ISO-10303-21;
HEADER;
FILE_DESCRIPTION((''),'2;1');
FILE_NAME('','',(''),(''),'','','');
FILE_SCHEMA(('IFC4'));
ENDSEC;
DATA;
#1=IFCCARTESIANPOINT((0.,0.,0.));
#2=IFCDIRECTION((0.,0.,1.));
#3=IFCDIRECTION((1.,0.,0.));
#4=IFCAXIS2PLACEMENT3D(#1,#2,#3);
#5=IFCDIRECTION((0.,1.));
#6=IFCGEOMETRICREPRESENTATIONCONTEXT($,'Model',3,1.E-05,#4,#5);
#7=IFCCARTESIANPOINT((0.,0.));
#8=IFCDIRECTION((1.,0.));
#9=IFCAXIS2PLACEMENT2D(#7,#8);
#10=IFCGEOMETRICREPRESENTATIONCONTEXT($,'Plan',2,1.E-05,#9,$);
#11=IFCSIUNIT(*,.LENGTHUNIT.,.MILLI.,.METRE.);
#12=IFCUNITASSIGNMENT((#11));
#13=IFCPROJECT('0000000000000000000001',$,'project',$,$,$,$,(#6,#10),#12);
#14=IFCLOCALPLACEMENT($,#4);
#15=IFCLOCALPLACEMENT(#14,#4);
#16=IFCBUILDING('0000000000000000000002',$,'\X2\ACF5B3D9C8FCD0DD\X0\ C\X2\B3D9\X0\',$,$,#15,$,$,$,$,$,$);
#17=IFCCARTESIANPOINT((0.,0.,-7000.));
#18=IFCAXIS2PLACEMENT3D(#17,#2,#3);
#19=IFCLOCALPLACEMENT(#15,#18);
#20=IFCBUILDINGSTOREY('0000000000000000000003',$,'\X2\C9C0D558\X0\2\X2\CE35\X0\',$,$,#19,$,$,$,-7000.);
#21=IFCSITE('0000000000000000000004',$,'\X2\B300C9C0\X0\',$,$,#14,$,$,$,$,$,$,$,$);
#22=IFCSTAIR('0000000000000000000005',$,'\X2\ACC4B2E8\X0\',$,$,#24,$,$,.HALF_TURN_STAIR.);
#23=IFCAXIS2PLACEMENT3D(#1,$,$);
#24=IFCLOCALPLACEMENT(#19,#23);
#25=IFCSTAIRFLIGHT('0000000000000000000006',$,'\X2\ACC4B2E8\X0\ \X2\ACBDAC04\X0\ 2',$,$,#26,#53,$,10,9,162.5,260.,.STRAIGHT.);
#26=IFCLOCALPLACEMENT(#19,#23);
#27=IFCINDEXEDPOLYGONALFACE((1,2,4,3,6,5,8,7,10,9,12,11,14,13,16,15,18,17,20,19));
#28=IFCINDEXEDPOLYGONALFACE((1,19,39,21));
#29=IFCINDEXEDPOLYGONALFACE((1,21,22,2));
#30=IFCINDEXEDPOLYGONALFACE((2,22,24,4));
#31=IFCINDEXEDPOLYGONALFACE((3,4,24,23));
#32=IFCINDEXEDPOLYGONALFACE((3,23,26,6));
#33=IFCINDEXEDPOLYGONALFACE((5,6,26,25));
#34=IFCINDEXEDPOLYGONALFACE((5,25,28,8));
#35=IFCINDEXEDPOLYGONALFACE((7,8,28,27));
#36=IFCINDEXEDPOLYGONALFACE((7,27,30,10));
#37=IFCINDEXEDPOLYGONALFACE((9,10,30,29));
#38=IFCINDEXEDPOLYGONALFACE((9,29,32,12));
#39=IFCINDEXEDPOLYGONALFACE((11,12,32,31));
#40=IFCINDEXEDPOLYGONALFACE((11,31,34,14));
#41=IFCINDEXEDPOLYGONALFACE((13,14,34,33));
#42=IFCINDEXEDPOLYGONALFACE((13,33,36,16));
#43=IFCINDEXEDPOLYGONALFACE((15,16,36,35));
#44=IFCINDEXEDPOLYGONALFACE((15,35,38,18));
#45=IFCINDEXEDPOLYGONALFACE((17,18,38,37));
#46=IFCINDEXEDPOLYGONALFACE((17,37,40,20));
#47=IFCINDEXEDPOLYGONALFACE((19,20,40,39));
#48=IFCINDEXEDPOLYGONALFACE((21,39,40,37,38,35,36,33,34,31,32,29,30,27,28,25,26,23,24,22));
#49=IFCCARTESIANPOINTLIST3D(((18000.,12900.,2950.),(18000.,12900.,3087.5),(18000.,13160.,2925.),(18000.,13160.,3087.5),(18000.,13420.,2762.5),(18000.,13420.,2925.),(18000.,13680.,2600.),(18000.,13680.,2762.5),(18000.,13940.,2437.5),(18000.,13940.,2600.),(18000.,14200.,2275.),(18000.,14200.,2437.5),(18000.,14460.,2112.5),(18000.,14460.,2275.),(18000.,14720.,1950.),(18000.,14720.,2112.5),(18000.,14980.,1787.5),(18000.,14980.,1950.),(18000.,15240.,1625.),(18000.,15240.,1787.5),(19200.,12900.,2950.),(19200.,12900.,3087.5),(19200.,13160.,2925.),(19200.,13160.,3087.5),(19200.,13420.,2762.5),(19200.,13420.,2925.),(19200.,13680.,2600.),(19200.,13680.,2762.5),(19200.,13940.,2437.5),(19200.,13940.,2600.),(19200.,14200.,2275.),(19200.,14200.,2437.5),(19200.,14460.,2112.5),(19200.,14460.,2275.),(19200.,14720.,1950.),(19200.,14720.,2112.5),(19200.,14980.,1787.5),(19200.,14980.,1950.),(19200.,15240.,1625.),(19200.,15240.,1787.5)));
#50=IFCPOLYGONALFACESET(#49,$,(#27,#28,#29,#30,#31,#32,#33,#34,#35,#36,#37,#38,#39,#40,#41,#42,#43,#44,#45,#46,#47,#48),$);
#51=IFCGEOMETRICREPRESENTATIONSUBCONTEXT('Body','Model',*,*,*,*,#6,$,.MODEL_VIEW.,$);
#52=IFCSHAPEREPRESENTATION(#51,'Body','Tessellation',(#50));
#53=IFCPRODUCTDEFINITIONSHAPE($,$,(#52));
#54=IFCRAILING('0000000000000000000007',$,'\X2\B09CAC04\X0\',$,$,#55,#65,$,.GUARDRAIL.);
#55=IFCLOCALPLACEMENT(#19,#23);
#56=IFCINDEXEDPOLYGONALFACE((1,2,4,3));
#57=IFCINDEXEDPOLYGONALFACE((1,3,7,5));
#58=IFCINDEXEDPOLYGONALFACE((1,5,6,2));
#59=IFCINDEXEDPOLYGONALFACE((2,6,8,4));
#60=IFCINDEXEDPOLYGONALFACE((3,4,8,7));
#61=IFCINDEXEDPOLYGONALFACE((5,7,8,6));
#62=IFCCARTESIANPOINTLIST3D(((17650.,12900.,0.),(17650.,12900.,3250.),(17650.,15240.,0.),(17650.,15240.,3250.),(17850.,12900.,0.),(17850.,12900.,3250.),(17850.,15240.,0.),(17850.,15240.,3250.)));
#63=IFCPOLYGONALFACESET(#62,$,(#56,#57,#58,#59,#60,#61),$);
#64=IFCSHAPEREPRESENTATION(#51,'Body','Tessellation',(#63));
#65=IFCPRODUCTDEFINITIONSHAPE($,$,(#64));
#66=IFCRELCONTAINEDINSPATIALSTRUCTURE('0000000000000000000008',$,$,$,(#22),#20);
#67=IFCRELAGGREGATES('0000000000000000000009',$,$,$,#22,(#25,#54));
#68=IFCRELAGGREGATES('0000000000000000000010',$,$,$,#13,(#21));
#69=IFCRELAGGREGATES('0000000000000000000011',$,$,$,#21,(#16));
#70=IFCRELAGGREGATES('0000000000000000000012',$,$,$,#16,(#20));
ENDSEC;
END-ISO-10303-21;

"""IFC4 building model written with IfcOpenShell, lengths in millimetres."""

from ifc_helpers import new_model, si_unit, direction, frame, origin_with_axes, origin_2d_with_axis, place, context, subcontext, project, spatial, polyline, outline, extrude, element, aggregate, save


model = new_model("IFC4")

# Units and contexts
model_context = context("Model", 3, precision=1e-05, world=origin_with_axes(), true_north=direction((0.0, 1.0)))
plan_context = context("Plan", 2, precision=1e-05, world=origin_2d_with_axis())
body_context = subcontext(model_context, "Body", "Model", "MODEL_VIEW")
ifc_project = project(units=[si_unit("LENGTHUNIT", "METRE", prefix="MILLI")], contexts=[model_context, plan_context])

# Site, building, storey
site_placement = place(None, origin_with_axes())
site = spatial("IfcSite", under=ifc_project, at=site_placement, Name="대지")
building_placement = place(site_placement, origin_with_axes())
building = spatial("IfcBuilding", under=site, at=building_placement, Name="공동주택 C동")
storey_placement = place(building_placement, frame((0.0, 0.0, -7000.0), z_axis=(0.0, 0.0, 1.0), x_axis=(1.0, 0.0, 0.0)))
storey = spatial("IfcBuildingStorey", under=building, at=storey_placement, Name="지하2층", Elevation=-7000.0)

# Stair
stair_placement = place(storey_placement, origin_with_axes())
stair = element("IfcStair", 1, at=stair_placement, inside=storey, Name="계단", PredefinedType="HALF_TURN_STAIR")

# Stair flight
stair_flight_1_placement = place(stair_placement, origin_with_axes())
stair_flight_1 = element("IfcStairFlight", 2, at=stair_flight_1_placement, Name="계단 경간 2", NumberOfRisers=10, NumberOfTreads=9, PredefinedType="STRAIGHT", RiserHeight=162.5, TreadLength=260.0, context=body_context, shape_type="SweptSolid", body=[
    extrude(outline(polyline([(0.0, 0.0), (0.0, 162.5), (260.0, 162.5), (260.0, 325.0), (520.0, 325.0), (520.0, 487.5), (780.0, 487.5), (780.0, 650.0), (1040.0, 650.0), (1040.0, 812.5), (1300.0, 812.5), (1300.0, 975.0), (1560.0, 975.0), (1560.0, 1137.5), (1820.0, 1137.5), (1820.0, 1300.0), (2080.0, 1300.0), (2080.0, 1462.5), (2340.0, 1462.5), (2340.0, 1625.0), (2340.0, 1325.0), (0.0, 0.0)])), frame((19200.0, 15240.0, 1625.0), z_axis=(-1.0, 0.0, 0.0), x_axis=(0.0, -1.0, 0.0)), (0.0, 0.0, 1.0), 1200.0),
])

# Railing
railing_placement = place(stair_placement, origin_with_axes())
railing = element("IfcRailing", 3, at=railing_placement, Name="난간", PredefinedType="GUARDRAIL", context=body_context, shape_type="SweptSolid", body=[
    extrude(outline(polyline([(17650.0, 12900.0), (17850.0, 12900.0), (17850.0, 15240.0), (17650.0, 15240.0), (17650.0, 12900.0)])), origin_with_axes(), (0.0, 0.0, 1.0), 3250.0),
])
aggregate(stair, [stair_flight_1, railing])

save(model, "model.ifc")
